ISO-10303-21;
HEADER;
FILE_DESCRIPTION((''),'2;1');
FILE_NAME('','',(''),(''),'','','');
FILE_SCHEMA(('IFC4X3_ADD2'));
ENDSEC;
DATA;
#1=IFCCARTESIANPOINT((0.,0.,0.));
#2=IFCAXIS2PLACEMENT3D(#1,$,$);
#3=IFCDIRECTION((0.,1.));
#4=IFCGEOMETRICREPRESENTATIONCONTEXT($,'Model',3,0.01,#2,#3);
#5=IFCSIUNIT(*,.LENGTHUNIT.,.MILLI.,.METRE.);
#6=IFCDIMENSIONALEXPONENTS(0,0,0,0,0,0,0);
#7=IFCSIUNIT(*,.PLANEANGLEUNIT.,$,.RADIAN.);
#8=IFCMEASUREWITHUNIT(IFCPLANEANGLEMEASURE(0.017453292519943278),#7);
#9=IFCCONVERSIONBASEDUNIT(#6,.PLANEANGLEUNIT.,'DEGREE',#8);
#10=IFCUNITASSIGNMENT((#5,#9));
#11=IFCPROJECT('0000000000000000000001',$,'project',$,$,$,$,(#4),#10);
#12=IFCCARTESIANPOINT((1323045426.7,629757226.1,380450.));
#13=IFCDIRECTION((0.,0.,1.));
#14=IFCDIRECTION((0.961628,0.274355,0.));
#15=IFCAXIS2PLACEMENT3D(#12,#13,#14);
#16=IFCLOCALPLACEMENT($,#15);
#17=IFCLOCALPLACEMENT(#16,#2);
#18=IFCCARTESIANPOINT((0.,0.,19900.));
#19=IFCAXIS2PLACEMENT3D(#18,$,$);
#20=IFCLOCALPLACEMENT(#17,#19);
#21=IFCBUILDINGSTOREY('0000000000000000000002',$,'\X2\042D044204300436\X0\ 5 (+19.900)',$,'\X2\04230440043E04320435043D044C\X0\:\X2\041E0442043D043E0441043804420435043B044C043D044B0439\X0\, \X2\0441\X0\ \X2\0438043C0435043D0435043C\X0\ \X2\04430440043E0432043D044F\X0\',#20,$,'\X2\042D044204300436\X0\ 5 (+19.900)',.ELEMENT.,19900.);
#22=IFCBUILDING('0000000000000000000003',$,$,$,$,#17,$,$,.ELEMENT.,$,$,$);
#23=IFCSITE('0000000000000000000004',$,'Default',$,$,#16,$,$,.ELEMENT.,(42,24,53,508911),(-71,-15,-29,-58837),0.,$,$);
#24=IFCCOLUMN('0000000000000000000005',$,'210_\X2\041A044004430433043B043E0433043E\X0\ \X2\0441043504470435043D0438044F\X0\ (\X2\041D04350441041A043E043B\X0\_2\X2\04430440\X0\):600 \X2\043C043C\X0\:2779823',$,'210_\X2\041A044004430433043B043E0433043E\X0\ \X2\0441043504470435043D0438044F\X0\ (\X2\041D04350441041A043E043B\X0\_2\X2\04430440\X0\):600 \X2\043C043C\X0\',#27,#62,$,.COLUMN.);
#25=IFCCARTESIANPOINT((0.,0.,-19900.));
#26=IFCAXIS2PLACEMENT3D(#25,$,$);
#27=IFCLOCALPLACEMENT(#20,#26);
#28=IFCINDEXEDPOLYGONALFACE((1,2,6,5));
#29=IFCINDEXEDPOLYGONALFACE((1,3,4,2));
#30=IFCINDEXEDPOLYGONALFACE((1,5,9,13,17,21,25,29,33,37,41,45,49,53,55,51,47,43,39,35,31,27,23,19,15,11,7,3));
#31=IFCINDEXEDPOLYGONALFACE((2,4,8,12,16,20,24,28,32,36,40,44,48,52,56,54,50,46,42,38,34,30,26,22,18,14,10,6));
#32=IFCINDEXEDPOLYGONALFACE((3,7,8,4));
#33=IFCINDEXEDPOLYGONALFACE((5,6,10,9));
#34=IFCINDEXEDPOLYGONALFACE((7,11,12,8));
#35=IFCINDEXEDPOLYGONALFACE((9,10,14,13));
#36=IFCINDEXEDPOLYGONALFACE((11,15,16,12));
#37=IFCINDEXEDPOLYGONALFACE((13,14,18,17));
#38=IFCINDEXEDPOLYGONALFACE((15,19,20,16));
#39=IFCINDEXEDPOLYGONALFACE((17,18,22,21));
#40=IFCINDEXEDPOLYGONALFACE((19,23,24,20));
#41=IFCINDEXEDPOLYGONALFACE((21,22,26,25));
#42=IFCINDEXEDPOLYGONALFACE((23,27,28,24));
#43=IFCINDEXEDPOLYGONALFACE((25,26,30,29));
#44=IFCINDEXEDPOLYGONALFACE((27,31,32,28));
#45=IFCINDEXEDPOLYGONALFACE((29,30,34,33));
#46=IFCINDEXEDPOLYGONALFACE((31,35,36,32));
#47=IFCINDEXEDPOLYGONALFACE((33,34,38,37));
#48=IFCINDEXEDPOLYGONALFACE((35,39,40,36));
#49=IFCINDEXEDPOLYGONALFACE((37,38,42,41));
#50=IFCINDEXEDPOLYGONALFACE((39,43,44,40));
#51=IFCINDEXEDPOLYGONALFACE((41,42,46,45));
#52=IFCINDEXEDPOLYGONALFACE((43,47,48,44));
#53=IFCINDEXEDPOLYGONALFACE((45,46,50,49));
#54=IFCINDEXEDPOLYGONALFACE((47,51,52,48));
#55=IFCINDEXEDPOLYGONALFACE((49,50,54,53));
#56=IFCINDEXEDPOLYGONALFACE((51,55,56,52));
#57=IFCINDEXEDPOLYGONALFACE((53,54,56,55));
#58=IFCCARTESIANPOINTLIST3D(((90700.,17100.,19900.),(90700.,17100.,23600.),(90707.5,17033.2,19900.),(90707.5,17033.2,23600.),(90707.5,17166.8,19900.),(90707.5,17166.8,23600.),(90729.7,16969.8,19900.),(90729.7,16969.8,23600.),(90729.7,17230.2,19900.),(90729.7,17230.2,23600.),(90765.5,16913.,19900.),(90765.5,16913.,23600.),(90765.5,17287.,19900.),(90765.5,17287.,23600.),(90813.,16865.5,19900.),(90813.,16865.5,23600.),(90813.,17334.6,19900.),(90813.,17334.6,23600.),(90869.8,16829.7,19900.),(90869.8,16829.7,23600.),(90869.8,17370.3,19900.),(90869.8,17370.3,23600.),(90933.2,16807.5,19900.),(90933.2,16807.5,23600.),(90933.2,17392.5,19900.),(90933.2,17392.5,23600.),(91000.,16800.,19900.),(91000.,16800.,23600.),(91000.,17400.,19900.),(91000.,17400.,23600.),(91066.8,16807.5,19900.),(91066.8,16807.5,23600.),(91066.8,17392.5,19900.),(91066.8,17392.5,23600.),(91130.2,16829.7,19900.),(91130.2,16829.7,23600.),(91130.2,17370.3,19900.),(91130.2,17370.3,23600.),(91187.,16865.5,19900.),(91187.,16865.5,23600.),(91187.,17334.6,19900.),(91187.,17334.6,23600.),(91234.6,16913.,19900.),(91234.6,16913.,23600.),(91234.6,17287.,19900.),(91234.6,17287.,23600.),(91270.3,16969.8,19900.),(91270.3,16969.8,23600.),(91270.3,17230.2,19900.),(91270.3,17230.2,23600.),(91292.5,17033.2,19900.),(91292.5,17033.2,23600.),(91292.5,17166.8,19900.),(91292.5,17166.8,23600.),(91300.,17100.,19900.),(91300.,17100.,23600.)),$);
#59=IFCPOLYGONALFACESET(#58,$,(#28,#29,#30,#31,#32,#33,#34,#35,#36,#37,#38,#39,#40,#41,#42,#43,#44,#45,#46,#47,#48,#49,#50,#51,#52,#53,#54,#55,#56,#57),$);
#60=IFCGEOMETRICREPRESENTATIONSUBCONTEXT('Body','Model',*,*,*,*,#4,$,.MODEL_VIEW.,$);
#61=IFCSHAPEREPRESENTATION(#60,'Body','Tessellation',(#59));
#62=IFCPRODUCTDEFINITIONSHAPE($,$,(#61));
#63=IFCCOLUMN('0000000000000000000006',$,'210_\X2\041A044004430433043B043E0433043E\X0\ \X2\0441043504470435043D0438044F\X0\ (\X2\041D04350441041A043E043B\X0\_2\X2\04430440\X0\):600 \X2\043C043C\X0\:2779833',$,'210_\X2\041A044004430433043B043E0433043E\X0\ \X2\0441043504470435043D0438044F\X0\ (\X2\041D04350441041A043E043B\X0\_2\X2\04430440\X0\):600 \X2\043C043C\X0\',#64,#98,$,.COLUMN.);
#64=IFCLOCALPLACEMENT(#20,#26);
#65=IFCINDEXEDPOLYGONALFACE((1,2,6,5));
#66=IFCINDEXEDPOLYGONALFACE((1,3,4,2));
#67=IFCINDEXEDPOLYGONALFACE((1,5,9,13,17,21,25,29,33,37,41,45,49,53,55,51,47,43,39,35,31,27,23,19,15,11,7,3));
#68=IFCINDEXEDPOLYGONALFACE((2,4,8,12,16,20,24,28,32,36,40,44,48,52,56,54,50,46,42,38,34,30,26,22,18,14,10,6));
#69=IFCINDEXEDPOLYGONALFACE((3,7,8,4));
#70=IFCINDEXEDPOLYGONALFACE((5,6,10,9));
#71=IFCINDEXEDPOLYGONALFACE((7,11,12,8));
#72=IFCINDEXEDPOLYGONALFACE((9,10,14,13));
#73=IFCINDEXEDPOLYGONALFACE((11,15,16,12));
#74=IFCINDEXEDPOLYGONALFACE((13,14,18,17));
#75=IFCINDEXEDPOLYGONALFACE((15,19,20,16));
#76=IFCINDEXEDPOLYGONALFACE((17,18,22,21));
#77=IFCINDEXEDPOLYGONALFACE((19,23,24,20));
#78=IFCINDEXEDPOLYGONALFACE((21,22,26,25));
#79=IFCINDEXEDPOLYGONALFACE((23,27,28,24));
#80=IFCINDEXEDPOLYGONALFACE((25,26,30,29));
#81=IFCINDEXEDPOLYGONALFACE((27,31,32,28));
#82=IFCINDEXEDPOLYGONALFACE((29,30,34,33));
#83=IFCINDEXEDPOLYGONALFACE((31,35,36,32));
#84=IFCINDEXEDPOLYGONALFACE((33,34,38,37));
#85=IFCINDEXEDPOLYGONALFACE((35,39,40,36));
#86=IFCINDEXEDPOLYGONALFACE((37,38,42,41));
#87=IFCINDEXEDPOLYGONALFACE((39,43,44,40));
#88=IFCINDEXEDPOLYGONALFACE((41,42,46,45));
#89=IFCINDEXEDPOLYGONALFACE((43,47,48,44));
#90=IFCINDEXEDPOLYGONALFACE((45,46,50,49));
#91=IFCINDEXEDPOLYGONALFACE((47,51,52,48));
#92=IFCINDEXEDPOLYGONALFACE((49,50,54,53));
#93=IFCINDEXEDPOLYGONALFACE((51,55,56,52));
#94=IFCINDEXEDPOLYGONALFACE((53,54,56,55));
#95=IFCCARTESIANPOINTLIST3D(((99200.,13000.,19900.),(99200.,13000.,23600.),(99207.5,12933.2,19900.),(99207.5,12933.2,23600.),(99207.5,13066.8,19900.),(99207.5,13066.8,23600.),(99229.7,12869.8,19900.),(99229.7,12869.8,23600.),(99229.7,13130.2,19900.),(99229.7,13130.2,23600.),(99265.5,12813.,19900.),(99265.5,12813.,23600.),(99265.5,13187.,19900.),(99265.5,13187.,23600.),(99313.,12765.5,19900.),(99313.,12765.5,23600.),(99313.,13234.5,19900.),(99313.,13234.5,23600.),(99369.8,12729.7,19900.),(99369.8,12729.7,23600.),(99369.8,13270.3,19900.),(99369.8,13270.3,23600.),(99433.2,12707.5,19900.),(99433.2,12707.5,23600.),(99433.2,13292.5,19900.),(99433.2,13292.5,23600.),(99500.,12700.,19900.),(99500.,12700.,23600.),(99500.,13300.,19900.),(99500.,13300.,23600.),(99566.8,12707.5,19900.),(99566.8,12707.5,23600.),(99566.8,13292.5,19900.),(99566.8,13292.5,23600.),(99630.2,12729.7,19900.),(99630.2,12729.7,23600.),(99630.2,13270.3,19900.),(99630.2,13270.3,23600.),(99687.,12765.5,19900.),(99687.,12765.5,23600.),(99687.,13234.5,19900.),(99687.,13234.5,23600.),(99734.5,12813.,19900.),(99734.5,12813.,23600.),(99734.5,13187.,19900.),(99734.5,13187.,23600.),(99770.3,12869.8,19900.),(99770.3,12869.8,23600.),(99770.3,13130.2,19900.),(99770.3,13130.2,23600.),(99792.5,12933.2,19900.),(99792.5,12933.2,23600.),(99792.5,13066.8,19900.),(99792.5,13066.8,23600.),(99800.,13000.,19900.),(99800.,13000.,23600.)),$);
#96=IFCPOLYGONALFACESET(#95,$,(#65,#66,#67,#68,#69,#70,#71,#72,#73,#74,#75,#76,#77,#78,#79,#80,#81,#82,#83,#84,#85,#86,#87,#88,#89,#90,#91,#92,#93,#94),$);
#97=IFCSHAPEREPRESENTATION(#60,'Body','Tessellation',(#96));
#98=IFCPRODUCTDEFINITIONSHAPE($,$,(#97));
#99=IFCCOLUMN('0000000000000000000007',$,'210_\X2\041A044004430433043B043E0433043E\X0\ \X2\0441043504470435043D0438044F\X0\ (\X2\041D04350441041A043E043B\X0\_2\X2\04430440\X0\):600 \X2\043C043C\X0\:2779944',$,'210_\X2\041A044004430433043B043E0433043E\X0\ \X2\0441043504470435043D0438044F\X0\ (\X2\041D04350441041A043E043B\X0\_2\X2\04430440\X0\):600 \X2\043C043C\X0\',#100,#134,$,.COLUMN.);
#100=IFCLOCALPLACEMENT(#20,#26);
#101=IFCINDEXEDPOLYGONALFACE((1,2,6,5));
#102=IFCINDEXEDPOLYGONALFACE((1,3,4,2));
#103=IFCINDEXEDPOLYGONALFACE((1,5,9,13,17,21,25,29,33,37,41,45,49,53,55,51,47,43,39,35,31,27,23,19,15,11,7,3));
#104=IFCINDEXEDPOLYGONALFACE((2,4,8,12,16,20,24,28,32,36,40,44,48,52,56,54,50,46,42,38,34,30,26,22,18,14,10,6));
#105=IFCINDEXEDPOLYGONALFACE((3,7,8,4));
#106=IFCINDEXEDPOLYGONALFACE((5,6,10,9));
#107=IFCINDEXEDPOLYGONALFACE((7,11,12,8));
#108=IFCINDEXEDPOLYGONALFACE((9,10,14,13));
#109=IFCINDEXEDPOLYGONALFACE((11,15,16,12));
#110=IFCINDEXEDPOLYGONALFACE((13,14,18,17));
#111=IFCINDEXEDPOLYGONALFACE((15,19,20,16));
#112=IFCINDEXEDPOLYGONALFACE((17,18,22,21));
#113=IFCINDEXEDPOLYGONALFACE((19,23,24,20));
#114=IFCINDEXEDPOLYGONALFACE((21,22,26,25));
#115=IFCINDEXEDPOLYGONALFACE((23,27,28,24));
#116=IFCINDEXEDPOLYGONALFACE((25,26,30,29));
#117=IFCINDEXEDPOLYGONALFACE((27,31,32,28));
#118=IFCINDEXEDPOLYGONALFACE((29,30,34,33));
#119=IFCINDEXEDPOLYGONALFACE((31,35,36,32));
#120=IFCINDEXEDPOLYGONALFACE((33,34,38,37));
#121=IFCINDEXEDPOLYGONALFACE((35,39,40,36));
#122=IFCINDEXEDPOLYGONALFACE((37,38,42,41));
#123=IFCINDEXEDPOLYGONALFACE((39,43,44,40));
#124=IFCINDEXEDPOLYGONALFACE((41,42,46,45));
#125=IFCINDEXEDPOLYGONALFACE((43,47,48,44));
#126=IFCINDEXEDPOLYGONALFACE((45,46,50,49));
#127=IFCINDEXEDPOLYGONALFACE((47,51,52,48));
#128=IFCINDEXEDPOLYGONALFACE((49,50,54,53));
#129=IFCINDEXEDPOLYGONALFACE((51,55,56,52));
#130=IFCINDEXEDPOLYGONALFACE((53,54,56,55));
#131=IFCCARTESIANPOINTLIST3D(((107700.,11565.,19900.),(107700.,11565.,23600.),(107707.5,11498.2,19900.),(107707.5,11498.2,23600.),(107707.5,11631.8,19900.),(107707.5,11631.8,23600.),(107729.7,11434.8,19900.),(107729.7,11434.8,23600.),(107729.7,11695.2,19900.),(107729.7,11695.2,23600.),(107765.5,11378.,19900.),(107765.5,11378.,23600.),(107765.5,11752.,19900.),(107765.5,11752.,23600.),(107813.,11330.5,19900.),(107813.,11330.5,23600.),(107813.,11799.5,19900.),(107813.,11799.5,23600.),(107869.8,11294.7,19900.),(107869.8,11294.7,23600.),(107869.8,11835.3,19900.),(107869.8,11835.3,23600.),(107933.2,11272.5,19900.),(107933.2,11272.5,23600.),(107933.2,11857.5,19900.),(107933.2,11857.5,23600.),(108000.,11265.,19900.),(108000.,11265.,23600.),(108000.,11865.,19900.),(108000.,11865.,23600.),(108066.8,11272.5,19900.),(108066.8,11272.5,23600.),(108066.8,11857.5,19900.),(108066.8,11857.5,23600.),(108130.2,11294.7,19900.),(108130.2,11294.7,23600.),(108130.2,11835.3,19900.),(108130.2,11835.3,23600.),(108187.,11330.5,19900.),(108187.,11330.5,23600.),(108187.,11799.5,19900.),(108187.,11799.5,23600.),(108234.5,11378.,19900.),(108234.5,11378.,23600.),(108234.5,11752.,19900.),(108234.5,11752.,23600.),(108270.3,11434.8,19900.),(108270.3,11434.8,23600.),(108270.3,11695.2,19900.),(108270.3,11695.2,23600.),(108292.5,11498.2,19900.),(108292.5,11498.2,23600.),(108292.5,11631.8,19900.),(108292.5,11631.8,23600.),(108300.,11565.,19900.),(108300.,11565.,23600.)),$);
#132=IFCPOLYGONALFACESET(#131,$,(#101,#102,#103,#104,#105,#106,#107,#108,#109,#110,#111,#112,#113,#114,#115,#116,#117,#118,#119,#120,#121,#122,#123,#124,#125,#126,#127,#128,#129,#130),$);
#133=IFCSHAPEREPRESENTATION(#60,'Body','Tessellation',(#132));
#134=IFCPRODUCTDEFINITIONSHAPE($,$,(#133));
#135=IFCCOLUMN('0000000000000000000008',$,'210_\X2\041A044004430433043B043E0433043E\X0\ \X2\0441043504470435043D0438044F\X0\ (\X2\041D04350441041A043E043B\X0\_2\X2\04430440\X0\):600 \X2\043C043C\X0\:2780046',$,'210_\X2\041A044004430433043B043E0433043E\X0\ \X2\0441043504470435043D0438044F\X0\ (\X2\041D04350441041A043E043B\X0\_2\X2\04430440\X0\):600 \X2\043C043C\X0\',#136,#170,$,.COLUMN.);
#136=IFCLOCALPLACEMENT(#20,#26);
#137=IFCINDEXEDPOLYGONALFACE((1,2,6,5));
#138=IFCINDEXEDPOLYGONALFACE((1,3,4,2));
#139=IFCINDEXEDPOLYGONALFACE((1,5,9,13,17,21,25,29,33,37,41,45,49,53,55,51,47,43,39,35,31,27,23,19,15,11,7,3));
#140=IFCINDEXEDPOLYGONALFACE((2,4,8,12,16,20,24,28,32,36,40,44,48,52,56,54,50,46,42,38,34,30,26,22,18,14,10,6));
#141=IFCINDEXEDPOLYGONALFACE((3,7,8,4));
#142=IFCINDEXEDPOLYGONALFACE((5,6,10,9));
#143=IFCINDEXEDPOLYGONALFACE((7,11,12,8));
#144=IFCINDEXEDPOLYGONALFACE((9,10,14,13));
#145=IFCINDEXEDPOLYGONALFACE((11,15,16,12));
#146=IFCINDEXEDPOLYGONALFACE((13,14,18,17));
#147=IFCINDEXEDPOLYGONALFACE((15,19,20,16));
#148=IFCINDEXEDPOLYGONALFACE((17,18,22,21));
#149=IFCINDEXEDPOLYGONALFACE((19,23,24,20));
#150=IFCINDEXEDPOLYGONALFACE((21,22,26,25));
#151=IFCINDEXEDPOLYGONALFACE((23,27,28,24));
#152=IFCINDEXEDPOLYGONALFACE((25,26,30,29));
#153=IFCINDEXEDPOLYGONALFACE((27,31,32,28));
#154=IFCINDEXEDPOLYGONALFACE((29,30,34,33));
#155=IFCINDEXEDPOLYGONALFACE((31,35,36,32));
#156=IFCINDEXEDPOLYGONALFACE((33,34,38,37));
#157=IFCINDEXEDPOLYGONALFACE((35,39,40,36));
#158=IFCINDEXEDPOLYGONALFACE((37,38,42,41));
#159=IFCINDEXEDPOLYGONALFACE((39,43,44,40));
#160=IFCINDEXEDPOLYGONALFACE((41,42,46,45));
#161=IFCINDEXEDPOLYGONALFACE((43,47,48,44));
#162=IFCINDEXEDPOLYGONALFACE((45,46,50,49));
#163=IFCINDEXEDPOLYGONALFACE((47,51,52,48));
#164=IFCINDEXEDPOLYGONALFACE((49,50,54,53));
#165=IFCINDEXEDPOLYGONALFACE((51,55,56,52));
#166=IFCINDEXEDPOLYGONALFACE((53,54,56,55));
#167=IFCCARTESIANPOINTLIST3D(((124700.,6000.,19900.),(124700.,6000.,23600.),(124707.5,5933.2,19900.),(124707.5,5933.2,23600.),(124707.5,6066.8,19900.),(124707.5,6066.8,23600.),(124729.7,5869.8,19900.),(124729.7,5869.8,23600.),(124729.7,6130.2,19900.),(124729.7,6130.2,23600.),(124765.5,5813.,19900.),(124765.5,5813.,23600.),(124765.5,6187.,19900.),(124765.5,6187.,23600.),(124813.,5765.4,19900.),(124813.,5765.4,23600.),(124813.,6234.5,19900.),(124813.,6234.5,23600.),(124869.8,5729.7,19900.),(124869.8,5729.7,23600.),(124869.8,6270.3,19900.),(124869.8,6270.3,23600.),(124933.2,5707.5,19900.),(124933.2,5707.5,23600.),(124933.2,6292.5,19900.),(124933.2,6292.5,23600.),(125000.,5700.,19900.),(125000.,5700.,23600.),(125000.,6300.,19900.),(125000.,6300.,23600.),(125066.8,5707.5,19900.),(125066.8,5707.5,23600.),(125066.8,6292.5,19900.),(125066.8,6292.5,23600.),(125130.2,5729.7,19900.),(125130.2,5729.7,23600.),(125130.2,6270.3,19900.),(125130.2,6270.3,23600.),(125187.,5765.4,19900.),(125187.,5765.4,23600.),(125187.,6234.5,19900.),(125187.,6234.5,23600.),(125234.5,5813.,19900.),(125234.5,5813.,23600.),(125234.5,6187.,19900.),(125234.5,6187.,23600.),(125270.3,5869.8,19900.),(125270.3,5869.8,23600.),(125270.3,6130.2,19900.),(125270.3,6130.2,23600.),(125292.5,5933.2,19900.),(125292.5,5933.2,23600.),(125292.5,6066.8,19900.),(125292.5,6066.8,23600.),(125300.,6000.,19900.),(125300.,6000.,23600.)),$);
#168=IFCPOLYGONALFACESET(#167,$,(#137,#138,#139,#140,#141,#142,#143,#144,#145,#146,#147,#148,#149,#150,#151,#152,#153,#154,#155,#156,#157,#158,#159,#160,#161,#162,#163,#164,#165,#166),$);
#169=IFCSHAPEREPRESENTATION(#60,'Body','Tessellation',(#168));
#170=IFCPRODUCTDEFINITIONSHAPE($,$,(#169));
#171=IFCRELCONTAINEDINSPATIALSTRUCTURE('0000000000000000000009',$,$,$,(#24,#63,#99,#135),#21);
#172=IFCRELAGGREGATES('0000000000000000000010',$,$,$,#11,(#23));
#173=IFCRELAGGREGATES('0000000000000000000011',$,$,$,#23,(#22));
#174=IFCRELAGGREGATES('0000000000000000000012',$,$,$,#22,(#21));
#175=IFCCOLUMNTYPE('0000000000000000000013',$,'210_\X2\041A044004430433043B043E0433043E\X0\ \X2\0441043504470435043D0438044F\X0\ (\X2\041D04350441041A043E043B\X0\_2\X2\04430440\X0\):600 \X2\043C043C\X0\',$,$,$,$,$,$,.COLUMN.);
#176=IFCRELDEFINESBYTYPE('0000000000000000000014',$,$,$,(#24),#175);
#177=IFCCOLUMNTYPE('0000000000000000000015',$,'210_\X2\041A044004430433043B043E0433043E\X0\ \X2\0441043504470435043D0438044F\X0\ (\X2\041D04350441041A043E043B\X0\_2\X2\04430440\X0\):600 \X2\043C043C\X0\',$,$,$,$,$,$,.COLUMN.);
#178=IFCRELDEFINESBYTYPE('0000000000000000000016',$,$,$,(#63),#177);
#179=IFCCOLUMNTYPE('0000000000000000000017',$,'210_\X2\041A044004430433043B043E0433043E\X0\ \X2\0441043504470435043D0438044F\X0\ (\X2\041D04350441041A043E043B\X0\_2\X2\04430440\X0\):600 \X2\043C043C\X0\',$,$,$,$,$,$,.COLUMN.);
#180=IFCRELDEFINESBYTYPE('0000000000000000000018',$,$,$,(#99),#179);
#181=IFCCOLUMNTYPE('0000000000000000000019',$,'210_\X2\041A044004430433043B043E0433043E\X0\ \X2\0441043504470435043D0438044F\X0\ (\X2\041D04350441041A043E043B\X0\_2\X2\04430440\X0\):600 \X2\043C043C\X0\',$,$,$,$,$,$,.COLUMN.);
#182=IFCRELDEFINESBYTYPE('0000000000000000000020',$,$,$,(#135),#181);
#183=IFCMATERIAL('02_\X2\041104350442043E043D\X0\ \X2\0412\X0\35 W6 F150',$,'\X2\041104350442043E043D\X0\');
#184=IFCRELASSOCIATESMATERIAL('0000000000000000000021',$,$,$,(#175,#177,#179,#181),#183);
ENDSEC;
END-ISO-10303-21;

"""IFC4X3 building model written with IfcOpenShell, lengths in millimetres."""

from ifc_helpers import new_model, entity, si_unit, converted_unit, direction, frame, frame_2d, origin, origin_2d_with_axis, place, context, subcontext, project, spatial, circle, extrude, source, transform, mapped, material, material_profile, profile_set, type_object, type_shapes, element, save


model = new_model("IFC4X3")

# Units and contexts
model_context = context("Model", 3, precision=0.01, world=origin(), true_north=direction((0.0, 1.0)))
body_context = subcontext(model_context, "Body", "Model", "MODEL_VIEW")
ifc_project = project(units=[si_unit("LENGTHUNIT", "METRE", prefix="MILLI"), converted_unit("PLANEANGLEUNIT", "DEGREE", entity("IfcPlaneAngleMeasure", 0.017453292519943278), si_unit("PLANEANGLEUNIT", "RADIAN"), dimensions=[0, 0, 0, 0, 0, 0, 0])], contexts=[model_context])

# Site, building, storey
site_placement = place(None, frame((1323045426.7, 629757226.1, 380450.0), z_axis=(0.0, 0.0, 1.0), x_axis=(0.961628, 0.274355, 0.0)))
site = spatial("IfcSite", under=ifc_project, at=site_placement, Name="Default", CompositionType="ELEMENT", RefLatitude=(42, 24, 53, 508911), RefLongitude=(-71, -15, -29, -58837), RefElevation=0.0)
building_placement = place(site_placement, origin())
building = spatial("IfcBuilding", under=site, at=building_placement, CompositionType="ELEMENT")
storey_placement = place(building_placement, frame((0.0, 0.0, 19900.0)))
storey = spatial("IfcBuildingStorey", under=building, at=storey_placement, Name="Этаж 5 (+19.900)", ObjectType="Уровень:Относительный, с именем уровня", LongName="Этаж 5 (+19.900)", CompositionType="ELEMENT", Elevation=19900.0)

# Columns
ifc_material = material(Name="02_Бетон В35 W6 F150", Category="Бетон")
ifc_material_profile = material_profile(ifc_material, circle(Radius=300.0, at=origin_2d_with_axis()), Name="600 мм")
ifc_profile_set = profile_set([ifc_material_profile], Name="600 мм")
column_type_1 = type_object("IfcColumnType", Name="210_Круглого сечения (НесКол_2ур):600 мм", PredefinedType="COLUMN", material=ifc_profile_set)
shared_shape_1 = source(origin(), body_context, "Body", "SweptSolid", [
    extrude(circle(Radius=300.0, at=origin_2d_with_axis()), frame((91000.0, 17100.0, 19900.0)), (0.0, 0.0, 1.0), 3700.0),
])
type_shapes(column_type_1, [shared_shape_1])
column_1_placement = place(storey_placement, frame((0.0, 0.0, -19900.0)))
element("IfcColumn", 1, at=column_1_placement, inside=storey, type_object=column_type_1, Name="210_Круглого сечения (НесКол_2ур):600 мм:2779823", ObjectType="210_Круглого сечения (НесКол_2ур):600 мм", PredefinedType="COLUMN", context=body_context, shape_type="MappedRepresentation", body=[
    mapped(shared_shape_1, transform((0.0, 0.0, 0.0), scale=1.0)),
])
column_type_2 = type_object("IfcColumnType", Name="210_Круглого сечения (НесКол_2ур):600 мм", PredefinedType="COLUMN", material=ifc_profile_set)
shared_shape_2 = source(origin(), body_context, "Body", "SweptSolid", [
    extrude(circle(Radius=300.0, at=origin_2d_with_axis()), frame((99500.0, 13000.0, 19900.0)), (0.0, 0.0, 1.0), 3700.0),
])
type_shapes(column_type_2, [shared_shape_2])
column_2_placement = place(storey_placement, frame((0.0, 0.0, -19900.0)))
element("IfcColumn", 2, at=column_2_placement, inside=storey, type_object=column_type_2, Name="210_Круглого сечения (НесКол_2ур):600 мм:2779833", ObjectType="210_Круглого сечения (НесКол_2ур):600 мм", PredefinedType="COLUMN", context=body_context, shape_type="MappedRepresentation", body=[
    mapped(shared_shape_2, transform((0.0, 0.0, 0.0), scale=1.0)),
])
column_type_3 = type_object("IfcColumnType", Name="210_Круглого сечения (НесКол_2ур):600 мм", PredefinedType="COLUMN", material=ifc_profile_set)
shared_shape_3 = source(origin(), body_context, "Body", "SweptSolid", [
    extrude(circle(Radius=300.0, at=origin_2d_with_axis()), frame((108000.0, 11565.0, 19900.0)), (0.0, 0.0, 1.0), 3700.0),
])
type_shapes(column_type_3, [shared_shape_3])
column_3_placement = place(storey_placement, frame((0.0, 0.0, -19900.0)))
element("IfcColumn", 3, at=column_3_placement, inside=storey, type_object=column_type_3, Name="210_Круглого сечения (НесКол_2ур):600 мм:2779944", ObjectType="210_Круглого сечения (НесКол_2ур):600 мм", PredefinedType="COLUMN", context=body_context, shape_type="MappedRepresentation", body=[
    mapped(shared_shape_3, transform((0.0, 0.0, 0.0), scale=1.0)),
])
column_type_4 = type_object("IfcColumnType", Name="210_Круглого сечения (НесКол_2ур):600 мм", PredefinedType="COLUMN", material=ifc_profile_set)
shared_shape_4 = source(origin(), body_context, "Body", "SweptSolid", [
    extrude(circle(Radius=300.0, at=frame_2d((0.0, 0.0), x_axis=(1.0, 0.0))), frame((125000.0, 6000.0, 19900.0)), (0.0, 0.0, 1.0), 3700.0),
])
type_shapes(column_type_4, [shared_shape_4])
column_4_placement = place(storey_placement, frame((0.0, 0.0, -19900.0)))
element("IfcColumn", 4, at=column_4_placement, inside=storey, type_object=column_type_4, Name="210_Круглого сечения (НесКол_2ур):600 мм:2780046", ObjectType="210_Круглого сечения (НесКол_2ур):600 мм", PredefinedType="COLUMN", context=body_context, shape_type="MappedRepresentation", body=[
    mapped(shared_shape_4, transform((0.0, 0.0, 0.0), scale=1.0)),
])

save(model, "model.ifc")
